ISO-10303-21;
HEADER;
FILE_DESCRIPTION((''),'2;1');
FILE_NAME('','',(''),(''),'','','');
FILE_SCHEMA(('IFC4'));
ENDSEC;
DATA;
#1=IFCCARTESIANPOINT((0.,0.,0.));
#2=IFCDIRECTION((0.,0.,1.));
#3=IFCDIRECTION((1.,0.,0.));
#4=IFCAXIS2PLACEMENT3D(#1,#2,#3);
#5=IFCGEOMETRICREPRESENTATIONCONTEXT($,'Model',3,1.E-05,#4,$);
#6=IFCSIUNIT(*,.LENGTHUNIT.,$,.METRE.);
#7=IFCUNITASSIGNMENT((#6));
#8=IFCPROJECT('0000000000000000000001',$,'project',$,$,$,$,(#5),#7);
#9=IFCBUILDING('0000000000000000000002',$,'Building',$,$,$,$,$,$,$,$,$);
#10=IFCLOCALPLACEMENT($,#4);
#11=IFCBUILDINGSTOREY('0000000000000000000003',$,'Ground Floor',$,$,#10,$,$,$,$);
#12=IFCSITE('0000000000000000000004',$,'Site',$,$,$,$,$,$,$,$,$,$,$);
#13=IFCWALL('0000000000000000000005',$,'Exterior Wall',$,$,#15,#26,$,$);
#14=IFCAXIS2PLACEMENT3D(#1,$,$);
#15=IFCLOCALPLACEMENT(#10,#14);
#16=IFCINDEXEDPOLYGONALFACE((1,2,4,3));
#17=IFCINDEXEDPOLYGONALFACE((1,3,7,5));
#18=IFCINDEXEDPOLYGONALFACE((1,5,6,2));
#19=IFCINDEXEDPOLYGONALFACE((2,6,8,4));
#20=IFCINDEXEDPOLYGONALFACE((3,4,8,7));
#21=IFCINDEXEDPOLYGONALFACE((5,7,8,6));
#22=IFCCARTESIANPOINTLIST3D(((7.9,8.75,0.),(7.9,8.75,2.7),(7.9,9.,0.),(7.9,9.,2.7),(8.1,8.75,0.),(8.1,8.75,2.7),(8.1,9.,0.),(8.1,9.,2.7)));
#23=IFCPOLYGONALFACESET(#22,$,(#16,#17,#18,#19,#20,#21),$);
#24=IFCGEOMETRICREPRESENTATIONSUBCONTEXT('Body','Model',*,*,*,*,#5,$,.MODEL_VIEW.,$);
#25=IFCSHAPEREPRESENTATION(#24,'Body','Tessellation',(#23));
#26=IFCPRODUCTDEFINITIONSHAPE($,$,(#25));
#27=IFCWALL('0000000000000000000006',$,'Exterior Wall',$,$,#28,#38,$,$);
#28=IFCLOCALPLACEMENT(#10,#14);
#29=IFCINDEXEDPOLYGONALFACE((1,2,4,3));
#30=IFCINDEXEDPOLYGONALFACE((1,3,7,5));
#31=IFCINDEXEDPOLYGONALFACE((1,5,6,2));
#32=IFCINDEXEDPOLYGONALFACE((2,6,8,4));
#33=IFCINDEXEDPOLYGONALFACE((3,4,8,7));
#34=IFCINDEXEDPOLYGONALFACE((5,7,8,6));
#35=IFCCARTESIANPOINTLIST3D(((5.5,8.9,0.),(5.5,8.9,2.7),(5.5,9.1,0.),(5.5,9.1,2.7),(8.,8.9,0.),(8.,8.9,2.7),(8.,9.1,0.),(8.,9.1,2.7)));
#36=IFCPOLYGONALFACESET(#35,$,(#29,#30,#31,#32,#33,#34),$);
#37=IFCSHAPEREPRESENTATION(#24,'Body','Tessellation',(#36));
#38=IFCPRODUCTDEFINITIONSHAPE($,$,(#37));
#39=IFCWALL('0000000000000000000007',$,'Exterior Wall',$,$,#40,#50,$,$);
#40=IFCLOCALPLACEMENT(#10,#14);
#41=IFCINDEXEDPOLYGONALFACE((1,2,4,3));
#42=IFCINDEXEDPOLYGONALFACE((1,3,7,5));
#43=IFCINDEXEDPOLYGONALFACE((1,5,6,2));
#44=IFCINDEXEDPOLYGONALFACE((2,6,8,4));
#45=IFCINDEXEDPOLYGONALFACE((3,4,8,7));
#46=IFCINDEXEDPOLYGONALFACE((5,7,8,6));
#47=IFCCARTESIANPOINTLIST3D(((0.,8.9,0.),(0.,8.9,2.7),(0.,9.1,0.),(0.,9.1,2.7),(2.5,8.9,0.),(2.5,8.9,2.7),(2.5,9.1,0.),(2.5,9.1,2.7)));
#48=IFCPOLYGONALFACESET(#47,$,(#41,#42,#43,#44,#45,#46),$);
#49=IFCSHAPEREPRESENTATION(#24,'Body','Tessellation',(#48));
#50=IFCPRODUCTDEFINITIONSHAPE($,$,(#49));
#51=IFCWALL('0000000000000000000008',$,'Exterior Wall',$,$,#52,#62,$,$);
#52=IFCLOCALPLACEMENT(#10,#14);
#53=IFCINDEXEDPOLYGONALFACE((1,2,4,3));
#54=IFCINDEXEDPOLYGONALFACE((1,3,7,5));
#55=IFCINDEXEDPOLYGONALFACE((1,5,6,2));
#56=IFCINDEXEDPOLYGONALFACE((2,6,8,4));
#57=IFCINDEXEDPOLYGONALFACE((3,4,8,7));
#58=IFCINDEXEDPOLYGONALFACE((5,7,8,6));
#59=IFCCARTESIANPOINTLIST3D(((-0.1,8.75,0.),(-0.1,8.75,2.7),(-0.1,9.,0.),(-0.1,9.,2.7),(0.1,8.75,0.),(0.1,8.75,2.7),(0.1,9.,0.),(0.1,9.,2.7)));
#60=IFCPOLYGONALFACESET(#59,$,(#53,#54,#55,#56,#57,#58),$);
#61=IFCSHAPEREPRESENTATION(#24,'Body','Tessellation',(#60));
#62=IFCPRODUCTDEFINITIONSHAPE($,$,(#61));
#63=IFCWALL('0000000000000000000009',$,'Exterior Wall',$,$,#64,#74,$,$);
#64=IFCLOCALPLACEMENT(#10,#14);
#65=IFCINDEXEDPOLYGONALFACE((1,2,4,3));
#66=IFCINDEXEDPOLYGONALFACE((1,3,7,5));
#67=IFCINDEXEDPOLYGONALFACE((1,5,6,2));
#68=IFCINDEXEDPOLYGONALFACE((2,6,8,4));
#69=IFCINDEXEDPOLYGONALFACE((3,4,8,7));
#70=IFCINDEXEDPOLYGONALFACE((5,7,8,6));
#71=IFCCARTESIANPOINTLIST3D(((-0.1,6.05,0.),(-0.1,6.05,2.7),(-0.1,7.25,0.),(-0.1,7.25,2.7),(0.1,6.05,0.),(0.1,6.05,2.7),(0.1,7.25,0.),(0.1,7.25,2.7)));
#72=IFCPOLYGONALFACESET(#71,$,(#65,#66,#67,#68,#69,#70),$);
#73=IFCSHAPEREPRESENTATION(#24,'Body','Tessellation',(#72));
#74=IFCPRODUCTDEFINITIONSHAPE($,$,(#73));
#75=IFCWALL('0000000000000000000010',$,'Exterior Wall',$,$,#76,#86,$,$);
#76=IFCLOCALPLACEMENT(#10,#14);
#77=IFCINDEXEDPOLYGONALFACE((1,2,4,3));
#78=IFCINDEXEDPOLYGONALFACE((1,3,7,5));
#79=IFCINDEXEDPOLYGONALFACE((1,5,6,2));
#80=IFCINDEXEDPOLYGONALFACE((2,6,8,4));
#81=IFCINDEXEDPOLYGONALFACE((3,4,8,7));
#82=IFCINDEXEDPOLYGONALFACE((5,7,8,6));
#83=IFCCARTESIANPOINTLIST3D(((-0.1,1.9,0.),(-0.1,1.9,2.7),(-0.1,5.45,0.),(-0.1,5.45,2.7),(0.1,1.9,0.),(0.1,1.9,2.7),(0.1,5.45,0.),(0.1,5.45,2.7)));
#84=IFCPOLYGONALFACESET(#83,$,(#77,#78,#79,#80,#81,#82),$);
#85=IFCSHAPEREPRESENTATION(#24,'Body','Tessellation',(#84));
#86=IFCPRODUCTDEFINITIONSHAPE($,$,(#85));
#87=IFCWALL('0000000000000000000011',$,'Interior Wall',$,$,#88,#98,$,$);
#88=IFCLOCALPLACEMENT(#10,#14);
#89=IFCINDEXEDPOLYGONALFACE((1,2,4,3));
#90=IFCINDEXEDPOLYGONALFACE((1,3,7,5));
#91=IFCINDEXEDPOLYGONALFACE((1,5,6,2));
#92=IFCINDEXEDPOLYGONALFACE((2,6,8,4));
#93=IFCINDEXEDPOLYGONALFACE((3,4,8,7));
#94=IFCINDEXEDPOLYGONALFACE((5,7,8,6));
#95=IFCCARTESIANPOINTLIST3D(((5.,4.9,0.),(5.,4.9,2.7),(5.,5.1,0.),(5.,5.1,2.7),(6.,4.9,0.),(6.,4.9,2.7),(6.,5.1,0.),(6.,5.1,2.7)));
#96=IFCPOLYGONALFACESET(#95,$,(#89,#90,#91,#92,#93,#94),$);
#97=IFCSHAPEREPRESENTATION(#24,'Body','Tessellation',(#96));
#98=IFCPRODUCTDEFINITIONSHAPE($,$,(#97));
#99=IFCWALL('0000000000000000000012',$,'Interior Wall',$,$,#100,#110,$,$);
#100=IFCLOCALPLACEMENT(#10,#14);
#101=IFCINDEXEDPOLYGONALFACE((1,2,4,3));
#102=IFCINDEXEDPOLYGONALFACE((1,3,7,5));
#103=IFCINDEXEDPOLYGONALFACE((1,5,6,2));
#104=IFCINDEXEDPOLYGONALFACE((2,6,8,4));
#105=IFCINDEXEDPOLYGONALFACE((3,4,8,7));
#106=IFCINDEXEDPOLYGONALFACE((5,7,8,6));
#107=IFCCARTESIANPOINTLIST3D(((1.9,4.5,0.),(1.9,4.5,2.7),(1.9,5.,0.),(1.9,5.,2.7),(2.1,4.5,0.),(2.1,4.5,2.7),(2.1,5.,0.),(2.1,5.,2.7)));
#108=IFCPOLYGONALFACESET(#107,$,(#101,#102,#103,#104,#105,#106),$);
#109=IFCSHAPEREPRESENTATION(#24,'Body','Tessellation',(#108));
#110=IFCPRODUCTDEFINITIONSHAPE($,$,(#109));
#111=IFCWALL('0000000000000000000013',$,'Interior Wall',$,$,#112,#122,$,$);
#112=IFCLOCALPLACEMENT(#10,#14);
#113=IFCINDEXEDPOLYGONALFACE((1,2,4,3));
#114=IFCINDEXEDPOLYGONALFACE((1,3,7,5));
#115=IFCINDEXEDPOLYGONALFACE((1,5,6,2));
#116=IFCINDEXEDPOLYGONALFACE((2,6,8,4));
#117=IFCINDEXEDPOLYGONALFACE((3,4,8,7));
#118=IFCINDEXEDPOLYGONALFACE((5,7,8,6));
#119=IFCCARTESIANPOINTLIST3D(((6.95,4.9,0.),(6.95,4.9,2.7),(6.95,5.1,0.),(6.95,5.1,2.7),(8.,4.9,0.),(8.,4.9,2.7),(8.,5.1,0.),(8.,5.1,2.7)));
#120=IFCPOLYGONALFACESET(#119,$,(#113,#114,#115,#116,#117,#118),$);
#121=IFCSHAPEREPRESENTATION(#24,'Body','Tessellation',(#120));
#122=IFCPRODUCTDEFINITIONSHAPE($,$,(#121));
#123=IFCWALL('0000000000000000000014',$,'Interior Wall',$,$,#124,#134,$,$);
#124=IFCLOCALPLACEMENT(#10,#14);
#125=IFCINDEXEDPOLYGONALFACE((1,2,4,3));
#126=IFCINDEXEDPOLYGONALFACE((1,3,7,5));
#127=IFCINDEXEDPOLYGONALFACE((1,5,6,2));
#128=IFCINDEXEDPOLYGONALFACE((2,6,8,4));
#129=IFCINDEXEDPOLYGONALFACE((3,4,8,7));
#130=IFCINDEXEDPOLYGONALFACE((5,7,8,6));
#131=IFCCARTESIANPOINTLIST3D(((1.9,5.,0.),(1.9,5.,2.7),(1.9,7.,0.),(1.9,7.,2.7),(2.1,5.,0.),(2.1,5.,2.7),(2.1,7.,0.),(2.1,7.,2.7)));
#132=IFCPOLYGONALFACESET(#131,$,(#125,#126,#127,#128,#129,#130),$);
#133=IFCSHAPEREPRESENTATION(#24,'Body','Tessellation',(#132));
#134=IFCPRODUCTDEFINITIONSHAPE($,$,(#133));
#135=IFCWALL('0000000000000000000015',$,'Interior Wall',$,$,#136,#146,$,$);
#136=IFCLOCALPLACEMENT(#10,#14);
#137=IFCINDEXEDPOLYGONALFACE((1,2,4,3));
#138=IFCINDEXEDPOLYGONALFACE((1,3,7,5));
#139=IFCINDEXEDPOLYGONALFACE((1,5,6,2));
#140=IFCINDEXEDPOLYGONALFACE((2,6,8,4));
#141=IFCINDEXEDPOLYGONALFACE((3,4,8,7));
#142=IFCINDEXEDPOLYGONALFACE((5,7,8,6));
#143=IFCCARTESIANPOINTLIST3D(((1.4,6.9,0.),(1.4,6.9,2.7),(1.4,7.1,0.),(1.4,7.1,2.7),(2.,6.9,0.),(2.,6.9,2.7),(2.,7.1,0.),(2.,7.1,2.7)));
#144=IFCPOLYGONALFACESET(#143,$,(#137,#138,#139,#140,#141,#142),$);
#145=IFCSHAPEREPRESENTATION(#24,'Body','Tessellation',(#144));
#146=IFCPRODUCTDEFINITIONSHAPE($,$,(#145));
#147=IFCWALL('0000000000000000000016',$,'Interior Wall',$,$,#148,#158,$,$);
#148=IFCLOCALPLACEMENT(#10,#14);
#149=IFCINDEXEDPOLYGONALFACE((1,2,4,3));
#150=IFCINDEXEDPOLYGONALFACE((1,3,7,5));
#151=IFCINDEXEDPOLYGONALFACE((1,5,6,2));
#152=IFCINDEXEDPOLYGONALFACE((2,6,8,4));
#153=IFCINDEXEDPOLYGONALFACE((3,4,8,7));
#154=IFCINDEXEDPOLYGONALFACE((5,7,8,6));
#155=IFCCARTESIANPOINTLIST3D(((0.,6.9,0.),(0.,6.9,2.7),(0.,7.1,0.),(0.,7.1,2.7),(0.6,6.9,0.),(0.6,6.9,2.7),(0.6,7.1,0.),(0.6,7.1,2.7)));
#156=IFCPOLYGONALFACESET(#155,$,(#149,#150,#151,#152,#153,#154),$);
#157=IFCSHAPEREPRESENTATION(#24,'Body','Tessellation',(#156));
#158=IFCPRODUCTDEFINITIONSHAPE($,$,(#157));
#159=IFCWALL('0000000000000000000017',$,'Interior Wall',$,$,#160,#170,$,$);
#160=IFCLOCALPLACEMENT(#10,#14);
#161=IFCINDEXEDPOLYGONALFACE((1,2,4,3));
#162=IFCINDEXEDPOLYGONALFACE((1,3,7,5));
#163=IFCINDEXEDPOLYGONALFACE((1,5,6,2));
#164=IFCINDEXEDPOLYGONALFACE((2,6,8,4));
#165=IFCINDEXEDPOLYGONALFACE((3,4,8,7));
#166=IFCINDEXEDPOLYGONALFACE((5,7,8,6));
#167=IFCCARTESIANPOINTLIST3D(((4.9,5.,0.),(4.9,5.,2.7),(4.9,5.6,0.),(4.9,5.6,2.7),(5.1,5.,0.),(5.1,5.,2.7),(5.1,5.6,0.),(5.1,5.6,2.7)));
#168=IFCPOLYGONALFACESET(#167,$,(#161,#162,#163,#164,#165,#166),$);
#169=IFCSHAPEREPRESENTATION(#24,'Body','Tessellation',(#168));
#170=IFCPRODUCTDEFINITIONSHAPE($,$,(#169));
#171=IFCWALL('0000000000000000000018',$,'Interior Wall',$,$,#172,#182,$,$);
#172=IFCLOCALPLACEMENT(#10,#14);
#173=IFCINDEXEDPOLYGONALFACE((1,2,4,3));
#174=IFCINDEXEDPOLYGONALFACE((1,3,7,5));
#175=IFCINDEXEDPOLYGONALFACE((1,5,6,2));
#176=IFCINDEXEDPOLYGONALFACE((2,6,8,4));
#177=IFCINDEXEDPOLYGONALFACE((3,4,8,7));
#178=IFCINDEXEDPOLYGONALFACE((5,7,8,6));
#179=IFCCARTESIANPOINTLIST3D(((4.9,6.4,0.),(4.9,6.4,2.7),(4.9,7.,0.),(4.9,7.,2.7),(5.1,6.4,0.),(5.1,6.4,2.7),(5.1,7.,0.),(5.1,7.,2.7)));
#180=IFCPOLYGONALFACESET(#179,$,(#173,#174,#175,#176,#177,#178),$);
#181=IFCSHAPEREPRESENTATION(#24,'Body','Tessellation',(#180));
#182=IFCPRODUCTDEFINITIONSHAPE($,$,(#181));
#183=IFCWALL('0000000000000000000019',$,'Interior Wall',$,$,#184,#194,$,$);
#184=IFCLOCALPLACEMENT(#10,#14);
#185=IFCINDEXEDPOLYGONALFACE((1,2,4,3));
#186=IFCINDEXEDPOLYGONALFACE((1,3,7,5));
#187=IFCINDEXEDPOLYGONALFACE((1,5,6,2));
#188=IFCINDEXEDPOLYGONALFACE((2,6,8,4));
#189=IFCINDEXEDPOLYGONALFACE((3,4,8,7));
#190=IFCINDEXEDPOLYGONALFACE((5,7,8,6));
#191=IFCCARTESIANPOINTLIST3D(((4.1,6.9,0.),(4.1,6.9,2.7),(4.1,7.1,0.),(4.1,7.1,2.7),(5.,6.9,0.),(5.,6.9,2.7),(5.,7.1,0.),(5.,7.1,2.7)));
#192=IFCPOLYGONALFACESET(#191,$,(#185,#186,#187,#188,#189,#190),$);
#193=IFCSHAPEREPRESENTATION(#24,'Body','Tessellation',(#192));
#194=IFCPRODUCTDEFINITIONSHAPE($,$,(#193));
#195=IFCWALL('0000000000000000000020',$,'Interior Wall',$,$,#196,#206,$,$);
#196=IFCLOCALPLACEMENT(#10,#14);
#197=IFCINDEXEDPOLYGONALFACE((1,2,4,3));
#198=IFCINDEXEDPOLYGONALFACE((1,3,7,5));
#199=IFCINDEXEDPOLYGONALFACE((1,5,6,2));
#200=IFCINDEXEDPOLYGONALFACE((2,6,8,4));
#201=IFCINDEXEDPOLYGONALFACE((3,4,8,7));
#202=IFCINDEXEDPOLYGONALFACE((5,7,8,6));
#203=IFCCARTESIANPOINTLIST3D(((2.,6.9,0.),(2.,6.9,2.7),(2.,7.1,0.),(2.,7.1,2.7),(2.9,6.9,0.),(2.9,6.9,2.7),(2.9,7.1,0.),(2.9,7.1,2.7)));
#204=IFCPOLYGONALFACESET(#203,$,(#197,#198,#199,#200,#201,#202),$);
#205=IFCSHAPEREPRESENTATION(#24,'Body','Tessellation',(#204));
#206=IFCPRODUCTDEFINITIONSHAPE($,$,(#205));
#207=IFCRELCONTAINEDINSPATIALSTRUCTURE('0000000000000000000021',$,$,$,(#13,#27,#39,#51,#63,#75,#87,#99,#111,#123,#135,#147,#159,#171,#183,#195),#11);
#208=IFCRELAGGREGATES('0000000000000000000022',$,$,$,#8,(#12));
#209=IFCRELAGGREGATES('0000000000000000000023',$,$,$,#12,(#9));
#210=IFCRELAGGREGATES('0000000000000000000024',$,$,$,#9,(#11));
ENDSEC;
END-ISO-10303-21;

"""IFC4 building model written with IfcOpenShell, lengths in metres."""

from ifc_helpers import new_model, si_unit, frame, origin_with_axes, place, context, subcontext, project, spatial, indexed_curve, outline, extrude, element, save


model = new_model("IFC4")

# Units and contexts
model_context = context("Model", 3, precision=1e-05, world=origin_with_axes())
body_context = subcontext(model_context, "Body", "Model", "MODEL_VIEW")
ifc_project = project(units=[si_unit("LENGTHUNIT", "METRE")], contexts=[model_context])

# Site, building, storey
site = spatial("IfcSite", under=ifc_project, Name="Site")
building = spatial("IfcBuilding", under=site, Name="Building")
storey_placement = place(None, origin_with_axes())
storey = spatial("IfcBuildingStorey", under=building, at=storey_placement, Name="Ground Floor")

# Walls
wall_1_placement = place(storey_placement, frame((8.0, 8.75, 0.0), z_axis=(0.0, 0.0, 1.0), x_axis=(0.0, 1.0, 0.0)))
element("IfcWall", 1, at=wall_1_placement, inside=storey, Name="Exterior Wall", context=body_context, shape_type="SweptSolid", body=[
    extrude(outline(indexed_curve([(0.0, 0.0), (0.0, 0.2), (0.25, 0.2), (0.25, 0.0), (0.0, 0.0)], self_intersect=False)), frame((0.0, -0.1, 0.0), z_axis=(0.0, 0.0, 1.0), x_axis=(1.0, 0.0, 0.0)), (0.0, 0.0, 1.0), 2.7),
])
for number, where, z_axis, x_axis, name in (
    (2, (8.0, 9.0, 0.0), (0.0, 0.0, 1.0), (-1.0, 0.0, 0.0), "Exterior Wall"),
    (3, (2.5, 9.0, 0.0), (0.0, 0.0, 1.0), (-1.0, 0.0, 0.0), "Exterior Wall"),
):
    element("IfcWall", number, at=place(storey_placement, frame(where, z_axis=z_axis, x_axis=x_axis)), inside=storey, Name=name, context=body_context, shape_type="SweptSolid", body=[
        extrude(outline(indexed_curve([(0.0, 0.0), (0.0, 0.2), (2.5, 0.2), (2.5, 0.0), (0.0, 0.0)], self_intersect=False)), frame((0.0, -0.1, 0.0), z_axis=(0.0, 0.0, 1.0), x_axis=(1.0, 0.0, 0.0)), (0.0, 0.0, 1.0), 2.7),
    ])
wall_2_placement = place(storey_placement, frame((0.0, 9.0, 0.0), z_axis=(0.0, 0.0, 1.0), x_axis=(0.0, -1.0, 0.0)))
element("IfcWall", 4, at=wall_2_placement, inside=storey, Name="Exterior Wall", context=body_context, shape_type="SweptSolid", body=[
    extrude(outline(indexed_curve([(0.0, 0.0), (0.0, 0.2), (0.25, 0.2), (0.25, 0.0), (0.0, 0.0)], self_intersect=False)), frame((0.0, -0.1, 0.0), z_axis=(0.0, 0.0, 1.0), x_axis=(1.0, 0.0, 0.0)), (0.0, 0.0, 1.0), 2.7),
])
wall_3_placement = place(storey_placement, frame((0.0, 7.25, 0.0), z_axis=(0.0, 0.0, 1.0), x_axis=(0.0, -1.0, 0.0)))
element("IfcWall", 5, at=wall_3_placement, inside=storey, Name="Exterior Wall", context=body_context, shape_type="SweptSolid", body=[
    extrude(outline(indexed_curve([(0.0, 0.0), (0.0, 0.2), (1.2, 0.2), (1.2, 0.0), (0.0, 0.0)], self_intersect=False)), frame((0.0, -0.1, 0.0), z_axis=(0.0, 0.0, 1.0), x_axis=(1.0, 0.0, 0.0)), (0.0, 0.0, 1.0), 2.7),
])
wall_4_placement = place(storey_placement, frame((0.0, 5.45, 0.0), z_axis=(0.0, 0.0, 1.0), x_axis=(0.0, -1.0, 0.0)))
element("IfcWall", 6, at=wall_4_placement, inside=storey, Name="Exterior Wall", context=body_context, shape_type="SweptSolid", body=[
    extrude(outline(indexed_curve([(0.0, 0.0), (0.0, 0.2), (3.55, 0.2), (3.55, 0.0), (0.0, 0.0)], self_intersect=False)), frame((0.0, -0.1, 0.0), z_axis=(0.0, 0.0, 1.0), x_axis=(1.0, 0.0, 0.0)), (0.0, 0.0, 1.0), 2.7),
])
wall_5_placement = place(storey_placement, frame((6.0, 5.0, 0.0), z_axis=(0.0, 0.0, 1.0), x_axis=(-1.0, 0.0, 0.0)))
element("IfcWall", 7, at=wall_5_placement, inside=storey, Name="Interior Wall", context=body_context, shape_type="SweptSolid", body=[
    extrude(outline(indexed_curve([(0.0, 0.0), (0.0, 0.2), (1.0, 0.2), (1.0, 0.0), (0.0, 0.0)], self_intersect=False)), frame((0.0, -0.1, 0.0), z_axis=(0.0, 0.0, 1.0), x_axis=(1.0, 0.0, 0.0)), (0.0, 0.0, 1.0), 2.7),
])
wall_6_placement = place(storey_placement, frame((2.0, 5.0, 0.0), z_axis=(0.0, 0.0, 1.0), x_axis=(0.0, -1.0, 0.0)))
element("IfcWall", 8, at=wall_6_placement, inside=storey, Name="Interior Wall", context=body_context, shape_type="SweptSolid", body=[
    extrude(outline(indexed_curve([(0.0, 0.0), (0.0, 0.2), (0.5, 0.2), (0.5, 0.0), (0.0, 0.0)], self_intersect=False)), frame((0.0, -0.1, 0.0), z_axis=(0.0, 0.0, 1.0), x_axis=(1.0, 0.0, 0.0)), (0.0, 0.0, 1.0), 2.7),
])
wall_7_placement = place(storey_placement, frame((8.0, 5.0, 0.0), z_axis=(0.0, 0.0, 1.0), x_axis=(-1.0, 0.0, 0.0)))
element("IfcWall", 9, at=wall_7_placement, inside=storey, Name="Interior Wall", context=body_context, shape_type="SweptSolid", body=[
    extrude(outline(indexed_curve([(0.0, 0.0), (0.0, 0.2), (1.05, 0.2), (1.05, 0.0), (0.0, 0.0)], self_intersect=False)), frame((0.0, -0.1, 0.0), z_axis=(0.0, 0.0, 1.0), x_axis=(1.0, 0.0, 0.0)), (0.0, 0.0, 1.0), 2.7),
])
wall_8_placement = place(storey_placement, frame((2.0, 5.0, 0.0), z_axis=(0.0, 0.0, 1.0), x_axis=(0.0, 1.0, 0.0)))
element("IfcWall", 10, at=wall_8_placement, inside=storey, Name="Interior Wall", context=body_context, shape_type="SweptSolid", body=[
    extrude(outline(indexed_curve([(0.0, 0.0), (0.0, 0.2), (2.0, 0.2), (2.0, 0.0), (0.0, 0.0)], self_intersect=False)), frame((0.0, -0.1, 0.0), z_axis=(0.0, 0.0, 1.0), x_axis=(1.0, 0.0, 0.0)), (0.0, 0.0, 1.0), 2.7),
])
for number, where, z_axis, x_axis, name in (
    (11, (2.0, 7.0, 0.0), (0.0, 0.0, 1.0), (-1.0, 0.0, 0.0), "Interior Wall"),
    (12, (0.6, 7.0, 0.0), (0.0, 0.0, 1.0), (-1.0, 0.0, 0.0), "Interior Wall"),
):
    element("IfcWall", number, at=place(storey_placement, frame(where, z_axis=z_axis, x_axis=x_axis)), inside=storey, Name=name, context=body_context, shape_type="SweptSolid", body=[
        extrude(outline(indexed_curve([(0.0, 0.0), (0.0, 0.2), (0.6, 0.2), (0.6, 0.0), (0.0, 0.0)], self_intersect=False)), frame((0.0, -0.1, 0.0), z_axis=(0.0, 0.0, 1.0), x_axis=(1.0, 0.0, 0.0)), (0.0, 0.0, 1.0), 2.7),
    ])
for number, where, z_axis, x_axis, name in (
    (13, (5.0, 5.0, 0.0), (0.0, 0.0, 1.0), (0.0, 1.0, 0.0), "Interior Wall"),
    (14, (5.0, 6.4, 0.0), (0.0, 0.0, 1.0), (0.0, 1.0, 0.0), "Interior Wall"),
):
    element("IfcWall", number, at=place(storey_placement, frame(where, z_axis=z_axis, x_axis=x_axis)), inside=storey, Name=name, context=body_context, shape_type="SweptSolid", body=[
        extrude(outline(indexed_curve([(0.0, 0.0), (0.0, 0.2), (0.6, 0.2), (0.6, 0.0), (0.0, 0.0)], self_intersect=False)), frame((0.0, -0.1, 0.0), z_axis=(0.0, 0.0, 1.0), x_axis=(1.0, 0.0, 0.0)), (0.0, 0.0, 1.0), 2.7),
    ])
wall_9_placement = place(storey_placement, frame((5.0, 7.0, 0.0), z_axis=(0.0, 0.0, 1.0), x_axis=(-1.0, 0.0, 0.0)))
element("IfcWall", 15, at=wall_9_placement, inside=storey, Name="Interior Wall", context=body_context, shape_type="SweptSolid", body=[
    extrude(outline(indexed_curve([(0.0, 0.0), (0.0, 0.2), (0.9, 0.2), (0.9, 0.0), (0.0, 0.0)], self_intersect=False)), frame((0.0, -0.1, 0.0), z_axis=(0.0, 0.0, 1.0), x_axis=(1.0, 0.0, 0.0)), (0.0, 0.0, 1.0), 2.7),
])
wall_10_placement = place(storey_placement, frame((2.9, 7.0, 0.0), z_axis=(0.0, 0.0, 1.0), x_axis=(-1.0, 0.0, 0.0)))
element("IfcWall", 16, at=wall_10_placement, inside=storey, Name="Interior Wall", context=body_context, shape_type="SweptSolid", body=[
    extrude(outline(indexed_curve([(0.0, 0.0), (0.0, 0.2), (0.9, 0.2), (0.9, 0.0), (0.0, 0.0)], self_intersect=False)), frame((0.0, -0.1, 0.0), z_axis=(0.0, 0.0, 1.0), x_axis=(1.0, 0.0, 0.0)), (0.0, 0.0, 1.0), 2.7),
])

save(model, "model.ifc")
